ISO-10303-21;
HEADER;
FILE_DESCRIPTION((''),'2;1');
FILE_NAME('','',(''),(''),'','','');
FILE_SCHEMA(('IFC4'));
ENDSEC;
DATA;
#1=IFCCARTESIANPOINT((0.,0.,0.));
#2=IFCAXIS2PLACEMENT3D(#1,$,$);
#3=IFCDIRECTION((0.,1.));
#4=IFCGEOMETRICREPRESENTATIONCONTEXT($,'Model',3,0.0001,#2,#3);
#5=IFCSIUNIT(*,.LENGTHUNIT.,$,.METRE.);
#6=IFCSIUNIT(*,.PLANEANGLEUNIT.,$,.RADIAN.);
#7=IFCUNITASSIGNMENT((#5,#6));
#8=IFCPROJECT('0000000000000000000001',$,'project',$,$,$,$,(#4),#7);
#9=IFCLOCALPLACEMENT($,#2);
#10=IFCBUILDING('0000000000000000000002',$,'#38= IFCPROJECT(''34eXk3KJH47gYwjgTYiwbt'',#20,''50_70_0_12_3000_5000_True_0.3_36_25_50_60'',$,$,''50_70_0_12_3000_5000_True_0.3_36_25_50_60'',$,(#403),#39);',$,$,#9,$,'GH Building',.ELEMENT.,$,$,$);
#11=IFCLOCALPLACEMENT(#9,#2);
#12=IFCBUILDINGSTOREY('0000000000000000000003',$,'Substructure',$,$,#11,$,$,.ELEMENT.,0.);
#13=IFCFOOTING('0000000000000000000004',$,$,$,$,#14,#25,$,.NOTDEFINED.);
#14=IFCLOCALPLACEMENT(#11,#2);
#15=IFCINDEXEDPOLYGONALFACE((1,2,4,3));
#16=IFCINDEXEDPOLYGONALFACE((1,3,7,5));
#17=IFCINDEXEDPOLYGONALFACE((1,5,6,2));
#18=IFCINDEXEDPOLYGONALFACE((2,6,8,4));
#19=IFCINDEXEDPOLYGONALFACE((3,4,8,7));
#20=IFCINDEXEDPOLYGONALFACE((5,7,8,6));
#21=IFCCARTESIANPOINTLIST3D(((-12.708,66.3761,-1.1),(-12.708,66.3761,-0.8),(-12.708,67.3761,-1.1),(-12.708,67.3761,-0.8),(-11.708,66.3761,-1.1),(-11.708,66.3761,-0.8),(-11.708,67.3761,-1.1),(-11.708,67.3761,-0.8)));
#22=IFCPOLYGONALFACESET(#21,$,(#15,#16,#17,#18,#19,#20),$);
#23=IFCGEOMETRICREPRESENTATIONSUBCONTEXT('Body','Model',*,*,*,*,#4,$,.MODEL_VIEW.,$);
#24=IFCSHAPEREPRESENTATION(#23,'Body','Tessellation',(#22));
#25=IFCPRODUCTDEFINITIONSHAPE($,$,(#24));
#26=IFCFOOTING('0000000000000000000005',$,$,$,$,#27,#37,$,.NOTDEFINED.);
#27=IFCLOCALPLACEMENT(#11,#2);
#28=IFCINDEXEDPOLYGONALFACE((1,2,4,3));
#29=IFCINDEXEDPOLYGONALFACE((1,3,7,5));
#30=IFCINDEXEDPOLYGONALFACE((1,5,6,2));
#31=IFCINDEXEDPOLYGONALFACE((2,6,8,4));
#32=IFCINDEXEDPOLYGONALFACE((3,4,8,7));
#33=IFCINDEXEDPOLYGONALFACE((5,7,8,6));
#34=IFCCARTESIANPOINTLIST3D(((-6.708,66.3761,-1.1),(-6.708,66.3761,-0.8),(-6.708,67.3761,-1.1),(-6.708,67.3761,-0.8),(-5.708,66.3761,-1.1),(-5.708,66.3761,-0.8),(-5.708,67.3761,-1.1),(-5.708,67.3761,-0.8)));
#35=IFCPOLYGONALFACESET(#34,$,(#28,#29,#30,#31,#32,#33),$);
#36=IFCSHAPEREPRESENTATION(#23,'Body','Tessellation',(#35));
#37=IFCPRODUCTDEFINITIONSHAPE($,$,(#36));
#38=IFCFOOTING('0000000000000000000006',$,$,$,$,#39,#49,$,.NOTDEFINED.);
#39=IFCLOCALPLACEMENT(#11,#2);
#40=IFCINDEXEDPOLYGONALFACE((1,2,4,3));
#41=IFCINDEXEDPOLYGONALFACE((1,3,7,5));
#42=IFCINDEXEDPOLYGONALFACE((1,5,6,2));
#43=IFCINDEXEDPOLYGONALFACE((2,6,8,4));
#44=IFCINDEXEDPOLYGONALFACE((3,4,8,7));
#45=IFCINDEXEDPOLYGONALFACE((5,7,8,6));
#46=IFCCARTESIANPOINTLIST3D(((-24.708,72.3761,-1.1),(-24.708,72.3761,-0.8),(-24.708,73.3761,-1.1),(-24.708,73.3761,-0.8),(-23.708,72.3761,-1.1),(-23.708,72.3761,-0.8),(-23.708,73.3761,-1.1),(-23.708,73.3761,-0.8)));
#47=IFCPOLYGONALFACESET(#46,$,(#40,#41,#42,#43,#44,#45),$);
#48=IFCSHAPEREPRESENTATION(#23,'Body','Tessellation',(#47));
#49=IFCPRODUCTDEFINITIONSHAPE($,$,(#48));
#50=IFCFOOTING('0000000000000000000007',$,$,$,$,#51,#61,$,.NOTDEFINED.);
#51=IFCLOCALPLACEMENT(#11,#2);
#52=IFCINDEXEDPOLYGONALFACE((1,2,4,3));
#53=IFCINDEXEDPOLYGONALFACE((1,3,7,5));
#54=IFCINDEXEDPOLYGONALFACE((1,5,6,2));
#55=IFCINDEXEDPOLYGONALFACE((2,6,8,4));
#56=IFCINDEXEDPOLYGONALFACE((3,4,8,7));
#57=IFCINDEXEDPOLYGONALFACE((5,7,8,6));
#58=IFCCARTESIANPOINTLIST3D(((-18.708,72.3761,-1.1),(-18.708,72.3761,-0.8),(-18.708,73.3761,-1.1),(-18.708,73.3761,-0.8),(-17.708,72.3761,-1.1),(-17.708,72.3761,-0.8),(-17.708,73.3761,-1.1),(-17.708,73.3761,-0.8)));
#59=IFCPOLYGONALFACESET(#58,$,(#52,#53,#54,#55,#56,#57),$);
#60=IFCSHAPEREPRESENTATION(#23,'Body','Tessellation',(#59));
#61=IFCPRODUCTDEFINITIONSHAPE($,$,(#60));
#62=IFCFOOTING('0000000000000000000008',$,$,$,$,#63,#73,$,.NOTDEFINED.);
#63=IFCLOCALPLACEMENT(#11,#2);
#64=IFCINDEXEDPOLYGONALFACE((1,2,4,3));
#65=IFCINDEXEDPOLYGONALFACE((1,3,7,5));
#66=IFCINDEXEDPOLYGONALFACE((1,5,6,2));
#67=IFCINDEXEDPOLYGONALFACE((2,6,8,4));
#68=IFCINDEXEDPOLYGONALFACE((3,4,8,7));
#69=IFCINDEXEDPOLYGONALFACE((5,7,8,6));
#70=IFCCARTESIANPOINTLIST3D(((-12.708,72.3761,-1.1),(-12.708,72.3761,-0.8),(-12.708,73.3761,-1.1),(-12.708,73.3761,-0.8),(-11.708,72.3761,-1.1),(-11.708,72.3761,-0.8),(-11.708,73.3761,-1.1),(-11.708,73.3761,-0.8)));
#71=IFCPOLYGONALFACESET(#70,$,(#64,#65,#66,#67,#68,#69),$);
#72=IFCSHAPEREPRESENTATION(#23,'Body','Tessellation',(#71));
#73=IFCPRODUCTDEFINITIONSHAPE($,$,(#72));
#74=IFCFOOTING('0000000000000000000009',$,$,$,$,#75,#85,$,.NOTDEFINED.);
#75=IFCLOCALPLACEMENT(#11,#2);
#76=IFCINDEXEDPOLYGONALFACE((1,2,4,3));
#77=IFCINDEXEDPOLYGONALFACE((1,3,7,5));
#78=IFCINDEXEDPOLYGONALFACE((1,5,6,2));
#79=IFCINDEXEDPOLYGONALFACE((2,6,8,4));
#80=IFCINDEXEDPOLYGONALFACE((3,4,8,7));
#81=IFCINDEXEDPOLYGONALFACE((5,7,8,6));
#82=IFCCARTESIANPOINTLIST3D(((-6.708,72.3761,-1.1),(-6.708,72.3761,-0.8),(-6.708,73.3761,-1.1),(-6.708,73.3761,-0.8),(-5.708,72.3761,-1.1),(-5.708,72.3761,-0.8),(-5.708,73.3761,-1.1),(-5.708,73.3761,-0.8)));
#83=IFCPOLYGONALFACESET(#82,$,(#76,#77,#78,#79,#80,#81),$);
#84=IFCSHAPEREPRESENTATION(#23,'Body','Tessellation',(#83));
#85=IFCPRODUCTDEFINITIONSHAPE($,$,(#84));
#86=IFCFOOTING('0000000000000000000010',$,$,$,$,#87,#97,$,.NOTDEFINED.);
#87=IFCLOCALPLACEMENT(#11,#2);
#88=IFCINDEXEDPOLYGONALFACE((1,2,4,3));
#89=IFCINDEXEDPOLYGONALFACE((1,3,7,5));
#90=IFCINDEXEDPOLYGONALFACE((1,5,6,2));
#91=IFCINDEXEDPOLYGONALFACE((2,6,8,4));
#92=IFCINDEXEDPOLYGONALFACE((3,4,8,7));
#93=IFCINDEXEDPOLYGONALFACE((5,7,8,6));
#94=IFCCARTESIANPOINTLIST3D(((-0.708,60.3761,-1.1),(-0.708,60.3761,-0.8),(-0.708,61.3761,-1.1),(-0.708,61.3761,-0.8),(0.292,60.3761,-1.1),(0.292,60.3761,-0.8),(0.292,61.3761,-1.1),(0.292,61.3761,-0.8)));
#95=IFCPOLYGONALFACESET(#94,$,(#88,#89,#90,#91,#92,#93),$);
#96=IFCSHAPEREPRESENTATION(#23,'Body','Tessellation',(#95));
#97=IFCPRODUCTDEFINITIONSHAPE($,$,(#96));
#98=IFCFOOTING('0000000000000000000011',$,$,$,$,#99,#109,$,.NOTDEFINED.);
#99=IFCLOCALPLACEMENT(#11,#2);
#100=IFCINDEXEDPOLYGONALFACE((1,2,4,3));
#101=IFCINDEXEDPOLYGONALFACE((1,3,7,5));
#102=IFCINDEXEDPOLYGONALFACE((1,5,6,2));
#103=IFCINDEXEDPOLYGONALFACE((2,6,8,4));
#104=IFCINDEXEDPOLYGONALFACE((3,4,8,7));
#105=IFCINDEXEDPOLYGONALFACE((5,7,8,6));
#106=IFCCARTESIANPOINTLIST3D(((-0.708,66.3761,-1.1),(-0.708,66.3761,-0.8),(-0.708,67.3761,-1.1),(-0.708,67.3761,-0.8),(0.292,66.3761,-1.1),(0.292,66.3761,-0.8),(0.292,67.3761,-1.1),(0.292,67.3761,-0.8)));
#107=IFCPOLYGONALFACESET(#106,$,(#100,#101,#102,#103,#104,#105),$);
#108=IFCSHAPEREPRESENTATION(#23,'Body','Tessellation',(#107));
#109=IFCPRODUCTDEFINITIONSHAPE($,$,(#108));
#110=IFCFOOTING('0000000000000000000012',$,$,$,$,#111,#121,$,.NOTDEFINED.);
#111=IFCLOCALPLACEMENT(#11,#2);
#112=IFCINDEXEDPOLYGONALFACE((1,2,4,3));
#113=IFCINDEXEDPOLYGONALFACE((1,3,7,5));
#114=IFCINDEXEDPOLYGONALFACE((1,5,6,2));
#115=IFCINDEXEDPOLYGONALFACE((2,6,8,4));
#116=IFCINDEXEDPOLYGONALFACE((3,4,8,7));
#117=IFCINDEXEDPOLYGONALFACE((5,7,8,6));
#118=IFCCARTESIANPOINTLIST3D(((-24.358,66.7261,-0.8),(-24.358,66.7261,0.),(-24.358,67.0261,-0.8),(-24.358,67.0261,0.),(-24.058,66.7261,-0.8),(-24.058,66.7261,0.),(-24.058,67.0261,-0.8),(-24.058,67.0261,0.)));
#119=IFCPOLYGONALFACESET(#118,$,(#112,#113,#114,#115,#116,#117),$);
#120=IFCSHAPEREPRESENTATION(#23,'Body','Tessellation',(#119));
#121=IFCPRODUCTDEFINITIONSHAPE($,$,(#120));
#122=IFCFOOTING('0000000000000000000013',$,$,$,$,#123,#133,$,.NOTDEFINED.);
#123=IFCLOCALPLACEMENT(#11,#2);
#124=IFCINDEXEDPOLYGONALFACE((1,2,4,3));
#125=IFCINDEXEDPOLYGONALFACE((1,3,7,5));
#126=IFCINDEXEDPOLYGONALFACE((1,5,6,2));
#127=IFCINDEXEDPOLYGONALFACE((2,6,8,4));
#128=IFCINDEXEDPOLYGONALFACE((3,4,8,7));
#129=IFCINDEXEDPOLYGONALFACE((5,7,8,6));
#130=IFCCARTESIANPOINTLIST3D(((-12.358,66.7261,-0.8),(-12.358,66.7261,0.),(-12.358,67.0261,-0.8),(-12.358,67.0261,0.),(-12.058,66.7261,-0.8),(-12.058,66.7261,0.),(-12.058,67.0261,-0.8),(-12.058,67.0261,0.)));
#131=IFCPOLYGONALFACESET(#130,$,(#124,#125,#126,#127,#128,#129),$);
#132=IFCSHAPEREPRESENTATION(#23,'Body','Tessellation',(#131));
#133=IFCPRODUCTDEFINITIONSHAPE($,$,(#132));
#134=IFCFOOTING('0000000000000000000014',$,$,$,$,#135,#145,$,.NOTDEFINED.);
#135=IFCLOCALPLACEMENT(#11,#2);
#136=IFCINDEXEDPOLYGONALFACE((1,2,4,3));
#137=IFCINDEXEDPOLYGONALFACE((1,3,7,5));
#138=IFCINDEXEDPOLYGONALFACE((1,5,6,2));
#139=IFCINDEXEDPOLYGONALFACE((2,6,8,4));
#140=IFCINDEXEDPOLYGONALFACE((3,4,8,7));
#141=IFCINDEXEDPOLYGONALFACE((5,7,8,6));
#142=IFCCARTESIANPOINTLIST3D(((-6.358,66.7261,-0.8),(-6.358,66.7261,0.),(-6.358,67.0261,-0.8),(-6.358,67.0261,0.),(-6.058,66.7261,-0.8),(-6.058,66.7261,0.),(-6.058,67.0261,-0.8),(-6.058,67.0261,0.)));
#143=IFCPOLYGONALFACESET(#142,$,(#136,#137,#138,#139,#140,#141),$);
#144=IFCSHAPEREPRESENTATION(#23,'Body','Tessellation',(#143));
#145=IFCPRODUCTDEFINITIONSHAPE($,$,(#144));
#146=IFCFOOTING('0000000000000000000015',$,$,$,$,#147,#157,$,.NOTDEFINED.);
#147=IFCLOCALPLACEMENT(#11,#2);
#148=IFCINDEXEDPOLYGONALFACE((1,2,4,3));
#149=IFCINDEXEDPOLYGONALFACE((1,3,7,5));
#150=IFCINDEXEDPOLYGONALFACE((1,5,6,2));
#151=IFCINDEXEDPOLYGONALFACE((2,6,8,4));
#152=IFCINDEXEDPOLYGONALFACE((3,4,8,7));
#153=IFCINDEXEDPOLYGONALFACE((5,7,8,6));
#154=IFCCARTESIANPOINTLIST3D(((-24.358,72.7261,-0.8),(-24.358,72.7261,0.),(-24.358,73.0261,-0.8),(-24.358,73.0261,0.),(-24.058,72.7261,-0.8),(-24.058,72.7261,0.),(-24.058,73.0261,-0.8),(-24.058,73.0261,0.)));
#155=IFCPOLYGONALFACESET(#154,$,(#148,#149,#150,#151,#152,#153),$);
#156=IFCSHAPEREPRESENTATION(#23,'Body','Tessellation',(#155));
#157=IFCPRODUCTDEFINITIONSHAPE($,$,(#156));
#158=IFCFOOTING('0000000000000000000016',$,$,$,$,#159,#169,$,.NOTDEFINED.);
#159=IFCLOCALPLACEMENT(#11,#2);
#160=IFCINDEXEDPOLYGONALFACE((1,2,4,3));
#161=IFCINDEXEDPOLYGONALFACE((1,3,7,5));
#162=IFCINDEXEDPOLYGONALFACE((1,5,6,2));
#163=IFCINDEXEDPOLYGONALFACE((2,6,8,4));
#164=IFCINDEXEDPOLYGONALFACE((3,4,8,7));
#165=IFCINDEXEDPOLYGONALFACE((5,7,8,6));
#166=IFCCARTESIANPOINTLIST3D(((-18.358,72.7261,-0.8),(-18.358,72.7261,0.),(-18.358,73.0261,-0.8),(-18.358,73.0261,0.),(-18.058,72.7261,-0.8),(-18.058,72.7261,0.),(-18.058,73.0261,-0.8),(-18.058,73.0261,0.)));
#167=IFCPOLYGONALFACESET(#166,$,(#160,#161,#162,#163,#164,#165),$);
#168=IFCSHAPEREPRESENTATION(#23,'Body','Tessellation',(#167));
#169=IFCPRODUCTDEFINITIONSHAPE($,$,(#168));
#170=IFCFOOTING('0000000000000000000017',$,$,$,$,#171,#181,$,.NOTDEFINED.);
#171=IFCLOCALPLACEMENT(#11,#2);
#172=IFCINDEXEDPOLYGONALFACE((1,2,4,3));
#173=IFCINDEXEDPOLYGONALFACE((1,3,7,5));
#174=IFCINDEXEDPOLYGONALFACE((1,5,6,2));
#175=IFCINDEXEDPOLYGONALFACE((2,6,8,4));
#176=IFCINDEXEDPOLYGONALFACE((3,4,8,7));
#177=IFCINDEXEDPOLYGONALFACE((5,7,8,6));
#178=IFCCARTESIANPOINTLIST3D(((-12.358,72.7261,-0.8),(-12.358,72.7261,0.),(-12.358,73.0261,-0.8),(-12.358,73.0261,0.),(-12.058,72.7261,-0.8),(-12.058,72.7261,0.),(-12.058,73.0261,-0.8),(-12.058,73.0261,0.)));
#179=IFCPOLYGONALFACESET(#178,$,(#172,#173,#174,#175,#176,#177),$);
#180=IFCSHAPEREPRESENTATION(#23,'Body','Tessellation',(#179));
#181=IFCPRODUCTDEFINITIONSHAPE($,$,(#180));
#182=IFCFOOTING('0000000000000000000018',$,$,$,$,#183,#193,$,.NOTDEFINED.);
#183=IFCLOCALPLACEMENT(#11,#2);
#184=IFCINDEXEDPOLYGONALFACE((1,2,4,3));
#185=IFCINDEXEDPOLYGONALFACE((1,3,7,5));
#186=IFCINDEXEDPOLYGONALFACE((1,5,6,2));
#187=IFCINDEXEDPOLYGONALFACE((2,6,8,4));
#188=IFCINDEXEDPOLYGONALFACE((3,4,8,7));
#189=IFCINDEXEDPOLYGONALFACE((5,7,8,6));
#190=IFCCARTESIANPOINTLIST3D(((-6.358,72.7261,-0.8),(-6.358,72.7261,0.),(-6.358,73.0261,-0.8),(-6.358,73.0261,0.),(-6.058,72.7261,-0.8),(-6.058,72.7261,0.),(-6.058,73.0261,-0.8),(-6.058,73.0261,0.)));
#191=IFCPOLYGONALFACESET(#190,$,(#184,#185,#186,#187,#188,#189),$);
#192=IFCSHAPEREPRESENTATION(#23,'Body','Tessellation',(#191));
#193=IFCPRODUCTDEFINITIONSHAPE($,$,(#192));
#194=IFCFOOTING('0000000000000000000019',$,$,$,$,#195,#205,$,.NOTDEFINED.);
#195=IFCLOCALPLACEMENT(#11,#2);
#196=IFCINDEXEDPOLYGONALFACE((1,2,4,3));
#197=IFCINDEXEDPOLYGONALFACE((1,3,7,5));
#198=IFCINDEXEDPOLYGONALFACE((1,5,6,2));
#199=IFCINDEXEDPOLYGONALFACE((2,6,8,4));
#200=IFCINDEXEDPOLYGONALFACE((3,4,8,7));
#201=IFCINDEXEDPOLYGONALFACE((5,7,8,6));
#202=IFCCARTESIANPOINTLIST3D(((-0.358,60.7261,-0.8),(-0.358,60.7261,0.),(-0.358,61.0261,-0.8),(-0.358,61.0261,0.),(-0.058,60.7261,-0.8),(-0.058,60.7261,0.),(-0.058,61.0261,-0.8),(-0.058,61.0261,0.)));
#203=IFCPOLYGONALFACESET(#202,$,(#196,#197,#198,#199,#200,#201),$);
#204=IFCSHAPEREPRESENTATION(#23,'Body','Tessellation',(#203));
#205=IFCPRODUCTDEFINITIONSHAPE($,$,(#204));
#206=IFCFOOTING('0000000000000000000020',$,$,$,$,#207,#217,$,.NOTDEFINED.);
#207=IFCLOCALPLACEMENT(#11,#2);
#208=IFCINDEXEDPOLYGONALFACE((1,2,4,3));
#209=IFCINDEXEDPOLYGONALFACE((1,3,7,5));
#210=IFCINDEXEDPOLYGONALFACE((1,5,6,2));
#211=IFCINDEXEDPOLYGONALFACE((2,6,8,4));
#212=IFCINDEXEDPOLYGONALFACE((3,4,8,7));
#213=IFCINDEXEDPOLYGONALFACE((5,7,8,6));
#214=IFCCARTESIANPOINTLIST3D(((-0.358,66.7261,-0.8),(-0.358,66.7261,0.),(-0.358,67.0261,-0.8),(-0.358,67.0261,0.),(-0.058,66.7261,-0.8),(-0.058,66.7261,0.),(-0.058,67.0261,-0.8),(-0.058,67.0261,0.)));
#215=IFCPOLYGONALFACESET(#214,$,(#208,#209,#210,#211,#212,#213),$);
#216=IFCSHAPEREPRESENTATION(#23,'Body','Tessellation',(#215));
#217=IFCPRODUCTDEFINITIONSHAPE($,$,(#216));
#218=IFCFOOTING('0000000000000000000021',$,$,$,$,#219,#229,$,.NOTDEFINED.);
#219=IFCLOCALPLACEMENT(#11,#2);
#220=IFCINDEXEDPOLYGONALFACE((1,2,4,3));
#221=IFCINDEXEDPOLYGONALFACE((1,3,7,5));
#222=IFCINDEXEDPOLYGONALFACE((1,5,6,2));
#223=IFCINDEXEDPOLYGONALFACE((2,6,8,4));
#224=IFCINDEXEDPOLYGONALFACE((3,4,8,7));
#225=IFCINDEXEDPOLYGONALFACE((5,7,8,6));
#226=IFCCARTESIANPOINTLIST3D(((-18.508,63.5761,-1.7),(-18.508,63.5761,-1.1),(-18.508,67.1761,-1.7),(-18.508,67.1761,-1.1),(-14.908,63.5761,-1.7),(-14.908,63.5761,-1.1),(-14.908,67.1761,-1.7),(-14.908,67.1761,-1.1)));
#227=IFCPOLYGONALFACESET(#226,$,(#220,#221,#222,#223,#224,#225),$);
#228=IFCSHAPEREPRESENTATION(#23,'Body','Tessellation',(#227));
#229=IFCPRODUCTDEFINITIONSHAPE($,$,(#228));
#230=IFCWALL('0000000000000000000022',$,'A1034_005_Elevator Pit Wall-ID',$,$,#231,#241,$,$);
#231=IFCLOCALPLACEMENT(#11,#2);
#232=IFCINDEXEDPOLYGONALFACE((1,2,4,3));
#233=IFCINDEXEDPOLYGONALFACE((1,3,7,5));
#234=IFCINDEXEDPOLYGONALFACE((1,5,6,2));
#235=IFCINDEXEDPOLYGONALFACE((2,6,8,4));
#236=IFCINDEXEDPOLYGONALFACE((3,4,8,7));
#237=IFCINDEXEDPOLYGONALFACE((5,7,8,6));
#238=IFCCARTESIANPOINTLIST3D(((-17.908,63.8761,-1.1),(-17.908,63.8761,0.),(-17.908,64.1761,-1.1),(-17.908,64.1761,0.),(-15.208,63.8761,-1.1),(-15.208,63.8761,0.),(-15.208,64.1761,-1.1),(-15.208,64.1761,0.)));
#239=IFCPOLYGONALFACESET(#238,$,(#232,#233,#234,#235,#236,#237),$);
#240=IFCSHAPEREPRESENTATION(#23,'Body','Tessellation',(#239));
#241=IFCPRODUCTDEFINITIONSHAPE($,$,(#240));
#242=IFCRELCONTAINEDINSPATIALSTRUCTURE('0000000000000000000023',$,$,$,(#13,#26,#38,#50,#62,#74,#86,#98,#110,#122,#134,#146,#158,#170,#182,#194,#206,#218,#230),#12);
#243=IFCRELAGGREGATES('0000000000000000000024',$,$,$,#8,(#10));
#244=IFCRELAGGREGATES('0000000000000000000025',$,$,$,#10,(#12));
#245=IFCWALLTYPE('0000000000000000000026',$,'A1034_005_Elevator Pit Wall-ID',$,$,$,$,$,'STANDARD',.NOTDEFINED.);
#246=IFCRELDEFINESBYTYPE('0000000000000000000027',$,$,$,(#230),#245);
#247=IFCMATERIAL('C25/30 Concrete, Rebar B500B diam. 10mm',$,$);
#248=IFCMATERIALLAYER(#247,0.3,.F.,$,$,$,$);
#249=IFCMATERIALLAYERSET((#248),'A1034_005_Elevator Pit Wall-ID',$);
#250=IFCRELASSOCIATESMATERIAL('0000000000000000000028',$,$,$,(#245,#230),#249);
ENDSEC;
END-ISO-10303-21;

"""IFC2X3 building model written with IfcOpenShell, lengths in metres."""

from ifc_helpers import new_model, si_unit, direction, frame, frame_2d, origin, origin_2d, place, context, subcontext, project, spatial, rectangle, extrude, source, transform, mapped, material, layer, layer_set, layer_usage, type_object, element, save


model = new_model("IFC2X3")

# Units and contexts
model_context = context("Model", 3, precision=0.0001, world=origin(), true_north=direction((0.0, 1.0)))
body_context = subcontext(model_context, "Body", "Model", "MODEL_VIEW")
ifc_project = project(units=[si_unit("LENGTHUNIT", "METRE"), si_unit("PLANEANGLEUNIT", "RADIAN")], contexts=[model_context])

# Building, storey
building_placement = place(None, origin())
building = spatial("IfcBuilding", under=ifc_project, at=building_placement, Name="#38= IFCPROJECT('34eXk3KJH47gYwjgTYiwbt',#20,'50_70_0_12_3000_5000_True_0.3_36_25_50_60',$,$,'50_70_0_12_3000_5000_True_0.3_36_25_50_60',$,(#403),#39);", LongName="GH Building", CompositionType="ELEMENT")
storey_placement = place(building_placement, origin())
storey = spatial("IfcBuildingStorey", under=building, at=storey_placement, Name="Substructure", CompositionType="ELEMENT", Elevation=0.0)

# Footings
shared_shape_1 = source(origin(), body_context, "Body", "SweptSolid", [
    extrude(rectangle(XDim=1.0, YDim=1.0, at=frame_2d((0.0, 0.0), x_axis=(0.0, -1.0))), origin(), (0.0, 0.0, 1.0), 0.3),
])
for number, where in (
    (1, (-12.208, 66.8761, -1.1)),
    (2, (-6.208, 66.8761, -1.1)),
    (3, (-24.208, 72.8761, -1.1)),
    (4, (-18.208, 72.8761, -1.1)),
    (5, (-12.208, 72.8761, -1.1)),
    (6, (-6.208, 72.8761, -1.1)),
    (7, (-0.208, 60.8761, -1.1)),
    (8, (-0.208, 66.8761, -1.1)),
):
    element("IfcFooting", number, at=place(storey_placement, frame(where)), inside=storey, PredefinedType="NOTDEFINED", context=body_context, shape_type="MappedRepresentation", body=[
        mapped(shared_shape_1, transform((0.0, 0.0, 0.0))),
    ])
shared_shape_2 = source(origin(), body_context, "Body", "SweptSolid", [
    extrude(rectangle(XDim=0.8, YDim=0.3, at=frame_2d((0.0, 0.0), x_axis=(0.0, 1.0))), frame((0.0, -0.15, 0.7), z_axis=(0.0, 1.0, 0.0), x_axis=(1.0, 0.0, 0.0)), (0.0, 0.0, 1.0), 0.3),
])
for number, where in (
    (9, (-24.208, 66.8761, -1.1)),
    (10, (-12.208, 66.8761, -1.1)),
    (11, (-6.208, 66.8761, -1.1)),
    (12, (-24.208, 72.8761, -1.1)),
    (13, (-18.208, 72.8761, -1.1)),
    (14, (-12.208, 72.8761, -1.1)),
    (15, (-6.208, 72.8761, -1.1)),
    (16, (-0.208, 60.8761, -1.1)),
    (17, (-0.208, 66.8761, -1.1)),
):
    element("IfcFooting", number, at=place(storey_placement, frame(where)), inside=storey, PredefinedType="NOTDEFINED", context=body_context, shape_type="MappedRepresentation", body=[
        mapped(shared_shape_2, transform((0.0, 0.0, 0.0))),
    ])
shared_shape_3 = source(origin(), body_context, "Body", "SweptSolid", [
    extrude(rectangle(XDim=3.6, YDim=3.6, at=origin_2d()), frame((0.0, 0.0, 0.0), z_axis=(0.0, 0.0, -1.0), x_axis=(1.0, 0.0, 0.0)), (0.0, 0.0, 1.0), 0.6),
])
footing_placement = place(storey_placement, frame((-16.708, 65.3761, -1.1)))
element("IfcFooting", 18, at=footing_placement, inside=storey, PredefinedType="NOTDEFINED", context=body_context, shape_type="MappedRepresentation", body=[
    mapped(shared_shape_3, transform((0.0, 0.0, 0.0))),
])

# Wall
ifc_material_1 = material(Name="C25/30 Concrete, Rebar B500B diam. 10mm")
ifc_layer = layer(ifc_material_1, 0.3, ventilated=False)
ifc_layer_set = layer_set([ifc_layer], Name="A1034_005_Elevator Pit Wall-ID")
ifc_layer_usage_1 = layer_usage(ifc_layer_set, "AXIS2", "POSITIVE", 0.0)
wall_type = type_object("IfcWallType", Name="A1034_005_Elevator Pit Wall-ID", ElementType="STANDARD", PredefinedType="NOTDEFINED", material=ifc_layer_set)
wall_1_placement = place(storey_placement, frame((-17.908, 63.8761, -1.1)))
element("IfcWall", 19, at=wall_1_placement, inside=storey, type_object=wall_type, material=ifc_layer_usage_1, Name="A1034_005_Elevator Pit Wall-ID", context=body_context, shape_type="SweptSolid", body=[
    extrude(rectangle(XDim=2.7, YDim=0.3, at=frame_2d((1.35, 0.15))), origin(), (0.0, 0.0, 1.0), 1.1),
])

save(model, "model.ifc")
